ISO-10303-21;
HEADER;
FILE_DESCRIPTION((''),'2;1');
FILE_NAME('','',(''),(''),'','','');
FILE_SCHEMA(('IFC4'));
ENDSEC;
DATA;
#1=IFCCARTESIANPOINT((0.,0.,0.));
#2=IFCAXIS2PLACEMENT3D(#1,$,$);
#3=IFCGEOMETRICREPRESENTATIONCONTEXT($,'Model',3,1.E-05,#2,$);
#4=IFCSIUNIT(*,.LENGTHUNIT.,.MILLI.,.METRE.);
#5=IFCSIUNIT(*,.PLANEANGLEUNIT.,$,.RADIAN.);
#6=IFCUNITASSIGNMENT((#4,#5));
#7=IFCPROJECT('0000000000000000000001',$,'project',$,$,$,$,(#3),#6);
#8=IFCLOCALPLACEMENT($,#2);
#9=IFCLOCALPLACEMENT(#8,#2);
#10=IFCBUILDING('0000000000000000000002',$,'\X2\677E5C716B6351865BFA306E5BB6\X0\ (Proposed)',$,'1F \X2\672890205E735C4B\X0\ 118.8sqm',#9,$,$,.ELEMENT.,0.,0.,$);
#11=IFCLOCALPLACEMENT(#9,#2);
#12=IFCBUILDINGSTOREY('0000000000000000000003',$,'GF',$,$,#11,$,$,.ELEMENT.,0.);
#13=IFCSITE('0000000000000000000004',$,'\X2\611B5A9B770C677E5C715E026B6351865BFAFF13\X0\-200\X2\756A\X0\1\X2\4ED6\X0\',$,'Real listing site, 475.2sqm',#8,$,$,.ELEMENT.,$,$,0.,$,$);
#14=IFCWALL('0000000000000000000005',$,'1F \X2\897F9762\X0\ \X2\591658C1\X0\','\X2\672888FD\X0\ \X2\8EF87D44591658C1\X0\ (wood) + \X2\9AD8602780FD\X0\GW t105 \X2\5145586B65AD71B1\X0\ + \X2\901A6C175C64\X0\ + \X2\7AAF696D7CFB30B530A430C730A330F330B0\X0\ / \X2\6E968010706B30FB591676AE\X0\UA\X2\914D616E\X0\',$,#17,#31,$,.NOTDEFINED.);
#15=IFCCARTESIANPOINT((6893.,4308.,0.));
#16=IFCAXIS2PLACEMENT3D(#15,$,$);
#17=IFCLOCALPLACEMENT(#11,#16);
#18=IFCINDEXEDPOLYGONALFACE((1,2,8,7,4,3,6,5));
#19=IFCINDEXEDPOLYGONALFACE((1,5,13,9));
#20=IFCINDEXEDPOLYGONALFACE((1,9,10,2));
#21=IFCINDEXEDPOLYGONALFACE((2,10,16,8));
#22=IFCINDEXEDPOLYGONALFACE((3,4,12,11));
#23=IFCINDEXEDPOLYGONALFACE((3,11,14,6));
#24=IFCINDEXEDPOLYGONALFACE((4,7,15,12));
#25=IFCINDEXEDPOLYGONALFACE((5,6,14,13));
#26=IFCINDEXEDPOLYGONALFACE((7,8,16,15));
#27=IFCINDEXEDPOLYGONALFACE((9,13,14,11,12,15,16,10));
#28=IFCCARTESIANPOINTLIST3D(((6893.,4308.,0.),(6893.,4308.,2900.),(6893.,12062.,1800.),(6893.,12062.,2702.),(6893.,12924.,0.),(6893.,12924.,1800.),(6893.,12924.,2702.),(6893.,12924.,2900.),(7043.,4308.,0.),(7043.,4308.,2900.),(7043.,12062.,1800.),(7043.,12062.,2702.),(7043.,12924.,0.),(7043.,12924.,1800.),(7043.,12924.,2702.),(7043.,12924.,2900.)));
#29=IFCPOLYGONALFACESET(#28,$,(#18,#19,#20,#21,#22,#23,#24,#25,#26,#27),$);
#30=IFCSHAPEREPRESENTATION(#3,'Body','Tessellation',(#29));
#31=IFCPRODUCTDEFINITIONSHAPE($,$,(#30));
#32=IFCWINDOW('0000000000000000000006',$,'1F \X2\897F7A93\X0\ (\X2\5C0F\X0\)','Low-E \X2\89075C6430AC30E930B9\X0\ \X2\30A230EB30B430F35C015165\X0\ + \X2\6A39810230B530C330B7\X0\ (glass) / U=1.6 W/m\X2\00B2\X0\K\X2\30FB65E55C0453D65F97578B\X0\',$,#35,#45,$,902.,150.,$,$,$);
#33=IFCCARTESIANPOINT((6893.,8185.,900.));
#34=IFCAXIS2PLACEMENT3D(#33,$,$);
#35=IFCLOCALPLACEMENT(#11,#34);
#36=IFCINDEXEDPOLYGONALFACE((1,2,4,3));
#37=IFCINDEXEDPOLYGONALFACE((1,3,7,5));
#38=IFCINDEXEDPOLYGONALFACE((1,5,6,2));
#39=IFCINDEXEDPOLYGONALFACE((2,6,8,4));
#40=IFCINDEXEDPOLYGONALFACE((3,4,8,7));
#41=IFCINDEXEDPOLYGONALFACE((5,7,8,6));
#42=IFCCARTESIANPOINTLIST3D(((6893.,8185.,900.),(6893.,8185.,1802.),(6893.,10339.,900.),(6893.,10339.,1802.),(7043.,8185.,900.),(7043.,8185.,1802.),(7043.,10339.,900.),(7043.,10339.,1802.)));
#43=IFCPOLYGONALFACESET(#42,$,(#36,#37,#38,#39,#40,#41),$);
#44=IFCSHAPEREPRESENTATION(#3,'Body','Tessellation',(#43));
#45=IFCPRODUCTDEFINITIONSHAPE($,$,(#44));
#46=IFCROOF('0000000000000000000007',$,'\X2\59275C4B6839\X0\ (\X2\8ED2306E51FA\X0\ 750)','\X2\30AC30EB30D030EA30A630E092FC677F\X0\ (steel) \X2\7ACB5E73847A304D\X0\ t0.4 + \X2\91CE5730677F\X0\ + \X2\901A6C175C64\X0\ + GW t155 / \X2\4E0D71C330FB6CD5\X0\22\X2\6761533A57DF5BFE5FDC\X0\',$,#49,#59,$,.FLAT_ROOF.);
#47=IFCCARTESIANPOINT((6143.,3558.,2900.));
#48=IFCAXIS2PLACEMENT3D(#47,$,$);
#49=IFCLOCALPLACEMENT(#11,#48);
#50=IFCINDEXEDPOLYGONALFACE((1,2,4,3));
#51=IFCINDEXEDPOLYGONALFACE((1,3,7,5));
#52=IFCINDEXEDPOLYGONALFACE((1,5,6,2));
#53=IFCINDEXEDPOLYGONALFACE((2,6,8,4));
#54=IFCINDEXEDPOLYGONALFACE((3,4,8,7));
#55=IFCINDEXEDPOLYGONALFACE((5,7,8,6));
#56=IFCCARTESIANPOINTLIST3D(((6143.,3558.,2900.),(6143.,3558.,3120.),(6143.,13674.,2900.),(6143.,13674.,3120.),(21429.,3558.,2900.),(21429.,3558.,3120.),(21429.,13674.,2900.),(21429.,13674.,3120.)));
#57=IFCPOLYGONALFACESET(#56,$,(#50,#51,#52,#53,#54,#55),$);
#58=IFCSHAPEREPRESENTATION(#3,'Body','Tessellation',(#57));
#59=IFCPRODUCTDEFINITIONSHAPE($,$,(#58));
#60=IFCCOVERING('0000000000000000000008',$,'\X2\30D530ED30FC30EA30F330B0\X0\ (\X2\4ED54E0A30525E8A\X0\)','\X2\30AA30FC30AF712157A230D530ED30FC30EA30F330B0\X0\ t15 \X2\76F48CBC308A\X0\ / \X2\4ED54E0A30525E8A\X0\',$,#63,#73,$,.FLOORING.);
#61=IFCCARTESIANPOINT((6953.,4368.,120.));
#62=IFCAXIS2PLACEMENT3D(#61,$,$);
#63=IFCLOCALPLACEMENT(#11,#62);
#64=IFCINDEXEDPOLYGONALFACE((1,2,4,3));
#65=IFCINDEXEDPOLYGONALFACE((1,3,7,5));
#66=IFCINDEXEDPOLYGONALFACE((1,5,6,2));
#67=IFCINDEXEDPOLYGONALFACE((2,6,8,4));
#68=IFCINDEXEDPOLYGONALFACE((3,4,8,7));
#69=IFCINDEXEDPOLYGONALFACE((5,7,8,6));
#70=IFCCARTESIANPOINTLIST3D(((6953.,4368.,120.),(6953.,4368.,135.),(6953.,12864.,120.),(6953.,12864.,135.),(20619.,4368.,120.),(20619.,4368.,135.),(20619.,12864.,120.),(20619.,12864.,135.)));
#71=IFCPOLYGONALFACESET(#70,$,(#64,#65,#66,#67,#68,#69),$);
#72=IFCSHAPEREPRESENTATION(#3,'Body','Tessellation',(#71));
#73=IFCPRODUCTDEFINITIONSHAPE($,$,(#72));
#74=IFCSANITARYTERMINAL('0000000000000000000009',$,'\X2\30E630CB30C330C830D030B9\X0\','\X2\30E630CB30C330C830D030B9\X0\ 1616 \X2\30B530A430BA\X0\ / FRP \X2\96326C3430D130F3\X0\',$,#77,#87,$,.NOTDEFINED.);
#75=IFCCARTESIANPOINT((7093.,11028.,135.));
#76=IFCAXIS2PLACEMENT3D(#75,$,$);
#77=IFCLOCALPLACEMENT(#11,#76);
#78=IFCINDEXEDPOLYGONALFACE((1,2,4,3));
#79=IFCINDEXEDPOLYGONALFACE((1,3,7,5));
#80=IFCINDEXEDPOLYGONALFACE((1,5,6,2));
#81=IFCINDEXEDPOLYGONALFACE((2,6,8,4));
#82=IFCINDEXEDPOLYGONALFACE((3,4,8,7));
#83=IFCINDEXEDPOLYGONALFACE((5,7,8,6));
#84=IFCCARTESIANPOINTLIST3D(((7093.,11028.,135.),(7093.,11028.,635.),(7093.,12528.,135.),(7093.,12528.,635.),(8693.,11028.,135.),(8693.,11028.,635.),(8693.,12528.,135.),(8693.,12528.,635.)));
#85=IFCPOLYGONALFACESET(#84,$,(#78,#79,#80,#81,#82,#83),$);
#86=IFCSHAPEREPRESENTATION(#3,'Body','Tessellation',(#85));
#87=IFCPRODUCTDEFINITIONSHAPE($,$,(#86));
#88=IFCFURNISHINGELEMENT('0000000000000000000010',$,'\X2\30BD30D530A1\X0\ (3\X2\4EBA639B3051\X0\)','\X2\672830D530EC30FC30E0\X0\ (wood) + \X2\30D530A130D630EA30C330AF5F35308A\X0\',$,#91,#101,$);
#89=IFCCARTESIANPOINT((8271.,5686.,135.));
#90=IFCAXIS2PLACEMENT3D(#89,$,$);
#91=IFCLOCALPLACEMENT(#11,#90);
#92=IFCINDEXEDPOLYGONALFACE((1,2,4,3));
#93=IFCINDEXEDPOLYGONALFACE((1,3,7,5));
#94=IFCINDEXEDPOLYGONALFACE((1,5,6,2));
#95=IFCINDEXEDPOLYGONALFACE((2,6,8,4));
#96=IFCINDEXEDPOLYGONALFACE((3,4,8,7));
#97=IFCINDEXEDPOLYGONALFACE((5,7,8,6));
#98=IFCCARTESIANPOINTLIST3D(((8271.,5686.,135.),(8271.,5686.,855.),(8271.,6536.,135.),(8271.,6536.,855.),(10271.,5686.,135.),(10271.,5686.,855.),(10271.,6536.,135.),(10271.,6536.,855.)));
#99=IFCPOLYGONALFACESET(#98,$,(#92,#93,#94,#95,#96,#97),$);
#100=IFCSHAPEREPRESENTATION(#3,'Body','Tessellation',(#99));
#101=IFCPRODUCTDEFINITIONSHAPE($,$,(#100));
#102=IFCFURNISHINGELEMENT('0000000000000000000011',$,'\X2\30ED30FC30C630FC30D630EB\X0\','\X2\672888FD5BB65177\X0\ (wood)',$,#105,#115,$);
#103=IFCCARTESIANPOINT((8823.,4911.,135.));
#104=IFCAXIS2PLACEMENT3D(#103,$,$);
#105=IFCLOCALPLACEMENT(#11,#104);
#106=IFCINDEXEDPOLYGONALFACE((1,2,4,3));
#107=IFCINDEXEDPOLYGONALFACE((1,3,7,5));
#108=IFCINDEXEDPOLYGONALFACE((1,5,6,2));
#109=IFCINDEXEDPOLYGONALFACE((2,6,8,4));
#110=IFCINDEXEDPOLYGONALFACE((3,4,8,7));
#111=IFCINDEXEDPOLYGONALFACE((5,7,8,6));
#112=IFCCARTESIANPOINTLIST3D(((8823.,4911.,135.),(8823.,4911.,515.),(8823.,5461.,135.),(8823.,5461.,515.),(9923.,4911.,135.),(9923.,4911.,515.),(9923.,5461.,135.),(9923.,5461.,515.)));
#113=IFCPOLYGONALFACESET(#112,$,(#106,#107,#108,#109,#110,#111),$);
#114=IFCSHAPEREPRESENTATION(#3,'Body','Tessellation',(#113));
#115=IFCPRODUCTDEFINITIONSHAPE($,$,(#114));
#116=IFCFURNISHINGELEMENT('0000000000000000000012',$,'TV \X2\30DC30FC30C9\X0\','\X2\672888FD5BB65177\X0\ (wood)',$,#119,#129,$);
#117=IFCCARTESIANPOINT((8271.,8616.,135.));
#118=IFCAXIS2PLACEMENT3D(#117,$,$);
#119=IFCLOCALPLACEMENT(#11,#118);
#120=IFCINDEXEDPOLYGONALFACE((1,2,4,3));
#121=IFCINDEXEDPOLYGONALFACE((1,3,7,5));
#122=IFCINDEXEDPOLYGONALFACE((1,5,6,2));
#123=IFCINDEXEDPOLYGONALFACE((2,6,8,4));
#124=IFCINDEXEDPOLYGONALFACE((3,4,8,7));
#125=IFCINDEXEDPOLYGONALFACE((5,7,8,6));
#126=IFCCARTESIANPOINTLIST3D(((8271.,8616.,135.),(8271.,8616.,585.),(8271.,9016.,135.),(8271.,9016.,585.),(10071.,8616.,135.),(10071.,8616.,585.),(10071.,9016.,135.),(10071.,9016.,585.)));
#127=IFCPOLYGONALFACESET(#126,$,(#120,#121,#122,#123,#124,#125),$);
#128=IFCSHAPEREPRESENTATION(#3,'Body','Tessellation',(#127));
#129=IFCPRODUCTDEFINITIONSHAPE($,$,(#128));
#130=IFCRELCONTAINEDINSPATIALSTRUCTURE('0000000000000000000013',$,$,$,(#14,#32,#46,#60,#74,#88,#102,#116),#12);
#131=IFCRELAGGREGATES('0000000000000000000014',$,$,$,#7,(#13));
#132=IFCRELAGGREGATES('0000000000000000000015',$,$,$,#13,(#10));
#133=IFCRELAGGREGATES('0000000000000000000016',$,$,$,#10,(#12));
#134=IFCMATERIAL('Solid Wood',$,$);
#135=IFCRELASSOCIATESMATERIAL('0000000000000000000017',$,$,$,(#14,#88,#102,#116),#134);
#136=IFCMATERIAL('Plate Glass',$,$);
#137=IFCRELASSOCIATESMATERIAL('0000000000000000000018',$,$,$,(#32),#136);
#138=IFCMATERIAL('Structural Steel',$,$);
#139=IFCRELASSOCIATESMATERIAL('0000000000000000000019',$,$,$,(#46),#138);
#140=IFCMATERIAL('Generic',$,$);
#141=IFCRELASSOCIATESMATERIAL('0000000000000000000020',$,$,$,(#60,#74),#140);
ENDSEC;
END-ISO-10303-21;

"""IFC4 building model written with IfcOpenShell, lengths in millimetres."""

from ifc_helpers import new_model, si_unit, frame, frame_2d, origin, place, context, project, spatial, rectangle, extrude, material, element, fill, save


model = new_model("IFC4")

# Units and contexts
model_context = context("Model", 3, precision=1e-05, world=origin())
ifc_project = project(units=[si_unit("LENGTHUNIT", "METRE", prefix="MILLI"), si_unit("PLANEANGLEUNIT", "RADIAN")], contexts=[model_context])

# Site, building, storey
site_placement = place(None, origin())
site = spatial("IfcSite", under=ifc_project, at=site_placement, Name="愛媛県松山市正円寺３-200番1他", ObjectType="Real listing site, 475.2sqm", CompositionType="ELEMENT", RefElevation=0.0)
building_placement = place(site_placement, origin())
building = spatial("IfcBuilding", under=site, at=building_placement, Name="松山正円寺の家 (Proposed)", ObjectType="1F 木造平屋 118.8sqm", CompositionType="ELEMENT", ElevationOfRefHeight=0.0, ElevationOfTerrain=0.0)
storey_placement = place(building_placement, origin())
storey = spatial("IfcBuildingStorey", under=building, at=storey_placement, Name="GF", CompositionType="ELEMENT", Elevation=0.0)

# Shared definitions
ifc_material_1 = material(Name="Solid Wood")

# Shared definitions
ifc_material_2 = material(Name="Plate Glass")

# Wall, opening, window
wall_1_placement = place(storey_placement, frame((6893.0, 4308.0, 0.0)))
wall_1 = element("IfcWall", 1, at=wall_1_placement, inside=storey, material=ifc_material_1, Name="1F 西面 外壁", Description="木製 軸組外壁 (wood) + 高性能GW t105 充填断熱 + 通気層 + 窯業系サイディング / 準耐火・外皮UA配慮", PredefinedType="NOTDEFINED", context=model_context, shape_type="SweptSolid", body=[
    extrude(rectangle(XDim=150.0, YDim=8616.0, at=frame_2d((75.0, 4308.0))), frame((6893.0, 4308.0, 0.0)), (0.0, 0.0, 1.0), 2900.0),
])
opening_1_placement = place(storey_placement, frame((6893.0, 8185.0, 900.0)))
opening_1 = element("IfcOpeningElement", 2, at=opening_1_placement, cuts=wall_1, PredefinedType="NOTDEFINED", context=model_context, shape_type="SweptSolid", body=[
    extrude(rectangle(XDim=150.0, YDim=2154.0, at=frame_2d((75.0, 1077.0))), frame((6893.0, 8185.0, 900.0)), (0.0, 0.0, 1.0), 902.0),
])
window_1_placement = place(storey_placement, frame((6893.0, 8185.0, 900.0)))
window_1 = element("IfcWindow", 3, at=window_1_placement, inside=storey, material=ifc_material_2, Name="1F 西窓 (小)", Description="Low-E 複層ガラス アルゴン封入 + 樹脂サッシ (glass) / U=1.6 W/m²K・日射取得型", OverallHeight=902.0, OverallWidth=150.0, context=model_context, shape_type="SweptSolid", body=[
    extrude(rectangle(XDim=150.0, YDim=2154.0, at=frame_2d((75.0, 1077.0))), frame((6893.0, 8185.0, 900.0)), (0.0, 0.0, 1.0), 902.0),
])
fill(opening_1, window_1)

# Roof
ifc_material_3 = material(Name="Structural Steel")
roof_placement = place(storey_placement, frame((6143.0, 3558.0, 2900.0)))
element("IfcRoof", 4, at=roof_placement, inside=storey, material=ifc_material_3, Name="大屋根 (軒の出 750)", Description="ガルバリウム鋼板 (steel) 立平葺き t0.4 + 野地板 + 通気層 + GW t155 / 不燃・法22条区域対応", PredefinedType="FLAT_ROOF", context=model_context, shape_type="SweptSolid", body=[
    extrude(rectangle(XDim=15286.0, YDim=10116.0, at=frame_2d((7643.0, 5058.0))), frame((6143.0, 3558.0, 2900.0)), (0.0, 0.0, 1.0), 220.0),
])

# Covering
ifc_material_4 = material(Name="Generic")
covering_placement = place(storey_placement, frame((6953.0, 4368.0, 120.0)))
element("IfcCovering", 5, at=covering_placement, inside=storey, material=ifc_material_4, Name="フローリング (仕上げ床)", Description="オーク無垢フローリング t15 直貼り / 仕上げ床", PredefinedType="FLOORING", context=model_context, shape_type="SweptSolid", body=[
    extrude(rectangle(XDim=13666.0, YDim=8496.0, at=frame_2d((6833.0, 4248.0))), frame((6953.0, 4368.0, 120.0)), (0.0, 0.0, 1.0), 15.0),
])

# Sanitary terminal
sanitary_terminal_placement = place(storey_placement, frame((7093.0, 11028.0, 135.0)))
element("IfcSanitaryTerminal", 6, at=sanitary_terminal_placement, inside=storey, material=ifc_material_4, Name="ユニットバス", Description="ユニットバス 1616 サイズ / FRP 防水パン", PredefinedType="NOTDEFINED", context=model_context, shape_type="SweptSolid", body=[
    extrude(rectangle(XDim=1600.0, YDim=1500.0, at=frame_2d((800.0, 750.0))), frame((7093.0, 11028.0, 135.0)), (0.0, 0.0, 1.0), 500.0),
])

# Furnishing elements
furnishing_1_placement = place(storey_placement, frame((8271.0, 5686.0, 135.0)))
element("IfcFurnishingElement", 7, at=furnishing_1_placement, inside=storey, material=ifc_material_1, Name="ソファ (3人掛け)", Description="木フレーム (wood) + ファブリック張り", context=model_context, shape_type="SweptSolid", body=[
    extrude(rectangle(XDim=2000.0, YDim=850.0, at=frame_2d((1000.0, 425.0))), frame((8271.0, 5686.0, 135.0)), (0.0, 0.0, 1.0), 720.0),
])
furnishing_2_placement = place(storey_placement, frame((8823.0, 4911.0, 135.0)))
element("IfcFurnishingElement", 8, at=furnishing_2_placement, inside=storey, material=ifc_material_1, Name="ローテーブル", Description="木製家具 (wood)", context=model_context, shape_type="SweptSolid", body=[
    extrude(rectangle(XDim=1100.0, YDim=550.0, at=frame_2d((550.0, 275.0))), frame((8823.0, 4911.0, 135.0)), (0.0, 0.0, 1.0), 380.0),
])
furnishing_3_placement = place(storey_placement, frame((8271.0, 8616.0, 135.0)))
element("IfcFurnishingElement", 9, at=furnishing_3_placement, inside=storey, material=ifc_material_1, Name="TV ボード", Description="木製家具 (wood)", context=model_context, shape_type="SweptSolid", body=[
    extrude(rectangle(XDim=1800.0, YDim=400.0, at=frame_2d((900.0, 200.0))), frame((8271.0, 8616.0, 135.0)), (0.0, 0.0, 1.0), 450.0),
])

save(model, "model.ifc")
